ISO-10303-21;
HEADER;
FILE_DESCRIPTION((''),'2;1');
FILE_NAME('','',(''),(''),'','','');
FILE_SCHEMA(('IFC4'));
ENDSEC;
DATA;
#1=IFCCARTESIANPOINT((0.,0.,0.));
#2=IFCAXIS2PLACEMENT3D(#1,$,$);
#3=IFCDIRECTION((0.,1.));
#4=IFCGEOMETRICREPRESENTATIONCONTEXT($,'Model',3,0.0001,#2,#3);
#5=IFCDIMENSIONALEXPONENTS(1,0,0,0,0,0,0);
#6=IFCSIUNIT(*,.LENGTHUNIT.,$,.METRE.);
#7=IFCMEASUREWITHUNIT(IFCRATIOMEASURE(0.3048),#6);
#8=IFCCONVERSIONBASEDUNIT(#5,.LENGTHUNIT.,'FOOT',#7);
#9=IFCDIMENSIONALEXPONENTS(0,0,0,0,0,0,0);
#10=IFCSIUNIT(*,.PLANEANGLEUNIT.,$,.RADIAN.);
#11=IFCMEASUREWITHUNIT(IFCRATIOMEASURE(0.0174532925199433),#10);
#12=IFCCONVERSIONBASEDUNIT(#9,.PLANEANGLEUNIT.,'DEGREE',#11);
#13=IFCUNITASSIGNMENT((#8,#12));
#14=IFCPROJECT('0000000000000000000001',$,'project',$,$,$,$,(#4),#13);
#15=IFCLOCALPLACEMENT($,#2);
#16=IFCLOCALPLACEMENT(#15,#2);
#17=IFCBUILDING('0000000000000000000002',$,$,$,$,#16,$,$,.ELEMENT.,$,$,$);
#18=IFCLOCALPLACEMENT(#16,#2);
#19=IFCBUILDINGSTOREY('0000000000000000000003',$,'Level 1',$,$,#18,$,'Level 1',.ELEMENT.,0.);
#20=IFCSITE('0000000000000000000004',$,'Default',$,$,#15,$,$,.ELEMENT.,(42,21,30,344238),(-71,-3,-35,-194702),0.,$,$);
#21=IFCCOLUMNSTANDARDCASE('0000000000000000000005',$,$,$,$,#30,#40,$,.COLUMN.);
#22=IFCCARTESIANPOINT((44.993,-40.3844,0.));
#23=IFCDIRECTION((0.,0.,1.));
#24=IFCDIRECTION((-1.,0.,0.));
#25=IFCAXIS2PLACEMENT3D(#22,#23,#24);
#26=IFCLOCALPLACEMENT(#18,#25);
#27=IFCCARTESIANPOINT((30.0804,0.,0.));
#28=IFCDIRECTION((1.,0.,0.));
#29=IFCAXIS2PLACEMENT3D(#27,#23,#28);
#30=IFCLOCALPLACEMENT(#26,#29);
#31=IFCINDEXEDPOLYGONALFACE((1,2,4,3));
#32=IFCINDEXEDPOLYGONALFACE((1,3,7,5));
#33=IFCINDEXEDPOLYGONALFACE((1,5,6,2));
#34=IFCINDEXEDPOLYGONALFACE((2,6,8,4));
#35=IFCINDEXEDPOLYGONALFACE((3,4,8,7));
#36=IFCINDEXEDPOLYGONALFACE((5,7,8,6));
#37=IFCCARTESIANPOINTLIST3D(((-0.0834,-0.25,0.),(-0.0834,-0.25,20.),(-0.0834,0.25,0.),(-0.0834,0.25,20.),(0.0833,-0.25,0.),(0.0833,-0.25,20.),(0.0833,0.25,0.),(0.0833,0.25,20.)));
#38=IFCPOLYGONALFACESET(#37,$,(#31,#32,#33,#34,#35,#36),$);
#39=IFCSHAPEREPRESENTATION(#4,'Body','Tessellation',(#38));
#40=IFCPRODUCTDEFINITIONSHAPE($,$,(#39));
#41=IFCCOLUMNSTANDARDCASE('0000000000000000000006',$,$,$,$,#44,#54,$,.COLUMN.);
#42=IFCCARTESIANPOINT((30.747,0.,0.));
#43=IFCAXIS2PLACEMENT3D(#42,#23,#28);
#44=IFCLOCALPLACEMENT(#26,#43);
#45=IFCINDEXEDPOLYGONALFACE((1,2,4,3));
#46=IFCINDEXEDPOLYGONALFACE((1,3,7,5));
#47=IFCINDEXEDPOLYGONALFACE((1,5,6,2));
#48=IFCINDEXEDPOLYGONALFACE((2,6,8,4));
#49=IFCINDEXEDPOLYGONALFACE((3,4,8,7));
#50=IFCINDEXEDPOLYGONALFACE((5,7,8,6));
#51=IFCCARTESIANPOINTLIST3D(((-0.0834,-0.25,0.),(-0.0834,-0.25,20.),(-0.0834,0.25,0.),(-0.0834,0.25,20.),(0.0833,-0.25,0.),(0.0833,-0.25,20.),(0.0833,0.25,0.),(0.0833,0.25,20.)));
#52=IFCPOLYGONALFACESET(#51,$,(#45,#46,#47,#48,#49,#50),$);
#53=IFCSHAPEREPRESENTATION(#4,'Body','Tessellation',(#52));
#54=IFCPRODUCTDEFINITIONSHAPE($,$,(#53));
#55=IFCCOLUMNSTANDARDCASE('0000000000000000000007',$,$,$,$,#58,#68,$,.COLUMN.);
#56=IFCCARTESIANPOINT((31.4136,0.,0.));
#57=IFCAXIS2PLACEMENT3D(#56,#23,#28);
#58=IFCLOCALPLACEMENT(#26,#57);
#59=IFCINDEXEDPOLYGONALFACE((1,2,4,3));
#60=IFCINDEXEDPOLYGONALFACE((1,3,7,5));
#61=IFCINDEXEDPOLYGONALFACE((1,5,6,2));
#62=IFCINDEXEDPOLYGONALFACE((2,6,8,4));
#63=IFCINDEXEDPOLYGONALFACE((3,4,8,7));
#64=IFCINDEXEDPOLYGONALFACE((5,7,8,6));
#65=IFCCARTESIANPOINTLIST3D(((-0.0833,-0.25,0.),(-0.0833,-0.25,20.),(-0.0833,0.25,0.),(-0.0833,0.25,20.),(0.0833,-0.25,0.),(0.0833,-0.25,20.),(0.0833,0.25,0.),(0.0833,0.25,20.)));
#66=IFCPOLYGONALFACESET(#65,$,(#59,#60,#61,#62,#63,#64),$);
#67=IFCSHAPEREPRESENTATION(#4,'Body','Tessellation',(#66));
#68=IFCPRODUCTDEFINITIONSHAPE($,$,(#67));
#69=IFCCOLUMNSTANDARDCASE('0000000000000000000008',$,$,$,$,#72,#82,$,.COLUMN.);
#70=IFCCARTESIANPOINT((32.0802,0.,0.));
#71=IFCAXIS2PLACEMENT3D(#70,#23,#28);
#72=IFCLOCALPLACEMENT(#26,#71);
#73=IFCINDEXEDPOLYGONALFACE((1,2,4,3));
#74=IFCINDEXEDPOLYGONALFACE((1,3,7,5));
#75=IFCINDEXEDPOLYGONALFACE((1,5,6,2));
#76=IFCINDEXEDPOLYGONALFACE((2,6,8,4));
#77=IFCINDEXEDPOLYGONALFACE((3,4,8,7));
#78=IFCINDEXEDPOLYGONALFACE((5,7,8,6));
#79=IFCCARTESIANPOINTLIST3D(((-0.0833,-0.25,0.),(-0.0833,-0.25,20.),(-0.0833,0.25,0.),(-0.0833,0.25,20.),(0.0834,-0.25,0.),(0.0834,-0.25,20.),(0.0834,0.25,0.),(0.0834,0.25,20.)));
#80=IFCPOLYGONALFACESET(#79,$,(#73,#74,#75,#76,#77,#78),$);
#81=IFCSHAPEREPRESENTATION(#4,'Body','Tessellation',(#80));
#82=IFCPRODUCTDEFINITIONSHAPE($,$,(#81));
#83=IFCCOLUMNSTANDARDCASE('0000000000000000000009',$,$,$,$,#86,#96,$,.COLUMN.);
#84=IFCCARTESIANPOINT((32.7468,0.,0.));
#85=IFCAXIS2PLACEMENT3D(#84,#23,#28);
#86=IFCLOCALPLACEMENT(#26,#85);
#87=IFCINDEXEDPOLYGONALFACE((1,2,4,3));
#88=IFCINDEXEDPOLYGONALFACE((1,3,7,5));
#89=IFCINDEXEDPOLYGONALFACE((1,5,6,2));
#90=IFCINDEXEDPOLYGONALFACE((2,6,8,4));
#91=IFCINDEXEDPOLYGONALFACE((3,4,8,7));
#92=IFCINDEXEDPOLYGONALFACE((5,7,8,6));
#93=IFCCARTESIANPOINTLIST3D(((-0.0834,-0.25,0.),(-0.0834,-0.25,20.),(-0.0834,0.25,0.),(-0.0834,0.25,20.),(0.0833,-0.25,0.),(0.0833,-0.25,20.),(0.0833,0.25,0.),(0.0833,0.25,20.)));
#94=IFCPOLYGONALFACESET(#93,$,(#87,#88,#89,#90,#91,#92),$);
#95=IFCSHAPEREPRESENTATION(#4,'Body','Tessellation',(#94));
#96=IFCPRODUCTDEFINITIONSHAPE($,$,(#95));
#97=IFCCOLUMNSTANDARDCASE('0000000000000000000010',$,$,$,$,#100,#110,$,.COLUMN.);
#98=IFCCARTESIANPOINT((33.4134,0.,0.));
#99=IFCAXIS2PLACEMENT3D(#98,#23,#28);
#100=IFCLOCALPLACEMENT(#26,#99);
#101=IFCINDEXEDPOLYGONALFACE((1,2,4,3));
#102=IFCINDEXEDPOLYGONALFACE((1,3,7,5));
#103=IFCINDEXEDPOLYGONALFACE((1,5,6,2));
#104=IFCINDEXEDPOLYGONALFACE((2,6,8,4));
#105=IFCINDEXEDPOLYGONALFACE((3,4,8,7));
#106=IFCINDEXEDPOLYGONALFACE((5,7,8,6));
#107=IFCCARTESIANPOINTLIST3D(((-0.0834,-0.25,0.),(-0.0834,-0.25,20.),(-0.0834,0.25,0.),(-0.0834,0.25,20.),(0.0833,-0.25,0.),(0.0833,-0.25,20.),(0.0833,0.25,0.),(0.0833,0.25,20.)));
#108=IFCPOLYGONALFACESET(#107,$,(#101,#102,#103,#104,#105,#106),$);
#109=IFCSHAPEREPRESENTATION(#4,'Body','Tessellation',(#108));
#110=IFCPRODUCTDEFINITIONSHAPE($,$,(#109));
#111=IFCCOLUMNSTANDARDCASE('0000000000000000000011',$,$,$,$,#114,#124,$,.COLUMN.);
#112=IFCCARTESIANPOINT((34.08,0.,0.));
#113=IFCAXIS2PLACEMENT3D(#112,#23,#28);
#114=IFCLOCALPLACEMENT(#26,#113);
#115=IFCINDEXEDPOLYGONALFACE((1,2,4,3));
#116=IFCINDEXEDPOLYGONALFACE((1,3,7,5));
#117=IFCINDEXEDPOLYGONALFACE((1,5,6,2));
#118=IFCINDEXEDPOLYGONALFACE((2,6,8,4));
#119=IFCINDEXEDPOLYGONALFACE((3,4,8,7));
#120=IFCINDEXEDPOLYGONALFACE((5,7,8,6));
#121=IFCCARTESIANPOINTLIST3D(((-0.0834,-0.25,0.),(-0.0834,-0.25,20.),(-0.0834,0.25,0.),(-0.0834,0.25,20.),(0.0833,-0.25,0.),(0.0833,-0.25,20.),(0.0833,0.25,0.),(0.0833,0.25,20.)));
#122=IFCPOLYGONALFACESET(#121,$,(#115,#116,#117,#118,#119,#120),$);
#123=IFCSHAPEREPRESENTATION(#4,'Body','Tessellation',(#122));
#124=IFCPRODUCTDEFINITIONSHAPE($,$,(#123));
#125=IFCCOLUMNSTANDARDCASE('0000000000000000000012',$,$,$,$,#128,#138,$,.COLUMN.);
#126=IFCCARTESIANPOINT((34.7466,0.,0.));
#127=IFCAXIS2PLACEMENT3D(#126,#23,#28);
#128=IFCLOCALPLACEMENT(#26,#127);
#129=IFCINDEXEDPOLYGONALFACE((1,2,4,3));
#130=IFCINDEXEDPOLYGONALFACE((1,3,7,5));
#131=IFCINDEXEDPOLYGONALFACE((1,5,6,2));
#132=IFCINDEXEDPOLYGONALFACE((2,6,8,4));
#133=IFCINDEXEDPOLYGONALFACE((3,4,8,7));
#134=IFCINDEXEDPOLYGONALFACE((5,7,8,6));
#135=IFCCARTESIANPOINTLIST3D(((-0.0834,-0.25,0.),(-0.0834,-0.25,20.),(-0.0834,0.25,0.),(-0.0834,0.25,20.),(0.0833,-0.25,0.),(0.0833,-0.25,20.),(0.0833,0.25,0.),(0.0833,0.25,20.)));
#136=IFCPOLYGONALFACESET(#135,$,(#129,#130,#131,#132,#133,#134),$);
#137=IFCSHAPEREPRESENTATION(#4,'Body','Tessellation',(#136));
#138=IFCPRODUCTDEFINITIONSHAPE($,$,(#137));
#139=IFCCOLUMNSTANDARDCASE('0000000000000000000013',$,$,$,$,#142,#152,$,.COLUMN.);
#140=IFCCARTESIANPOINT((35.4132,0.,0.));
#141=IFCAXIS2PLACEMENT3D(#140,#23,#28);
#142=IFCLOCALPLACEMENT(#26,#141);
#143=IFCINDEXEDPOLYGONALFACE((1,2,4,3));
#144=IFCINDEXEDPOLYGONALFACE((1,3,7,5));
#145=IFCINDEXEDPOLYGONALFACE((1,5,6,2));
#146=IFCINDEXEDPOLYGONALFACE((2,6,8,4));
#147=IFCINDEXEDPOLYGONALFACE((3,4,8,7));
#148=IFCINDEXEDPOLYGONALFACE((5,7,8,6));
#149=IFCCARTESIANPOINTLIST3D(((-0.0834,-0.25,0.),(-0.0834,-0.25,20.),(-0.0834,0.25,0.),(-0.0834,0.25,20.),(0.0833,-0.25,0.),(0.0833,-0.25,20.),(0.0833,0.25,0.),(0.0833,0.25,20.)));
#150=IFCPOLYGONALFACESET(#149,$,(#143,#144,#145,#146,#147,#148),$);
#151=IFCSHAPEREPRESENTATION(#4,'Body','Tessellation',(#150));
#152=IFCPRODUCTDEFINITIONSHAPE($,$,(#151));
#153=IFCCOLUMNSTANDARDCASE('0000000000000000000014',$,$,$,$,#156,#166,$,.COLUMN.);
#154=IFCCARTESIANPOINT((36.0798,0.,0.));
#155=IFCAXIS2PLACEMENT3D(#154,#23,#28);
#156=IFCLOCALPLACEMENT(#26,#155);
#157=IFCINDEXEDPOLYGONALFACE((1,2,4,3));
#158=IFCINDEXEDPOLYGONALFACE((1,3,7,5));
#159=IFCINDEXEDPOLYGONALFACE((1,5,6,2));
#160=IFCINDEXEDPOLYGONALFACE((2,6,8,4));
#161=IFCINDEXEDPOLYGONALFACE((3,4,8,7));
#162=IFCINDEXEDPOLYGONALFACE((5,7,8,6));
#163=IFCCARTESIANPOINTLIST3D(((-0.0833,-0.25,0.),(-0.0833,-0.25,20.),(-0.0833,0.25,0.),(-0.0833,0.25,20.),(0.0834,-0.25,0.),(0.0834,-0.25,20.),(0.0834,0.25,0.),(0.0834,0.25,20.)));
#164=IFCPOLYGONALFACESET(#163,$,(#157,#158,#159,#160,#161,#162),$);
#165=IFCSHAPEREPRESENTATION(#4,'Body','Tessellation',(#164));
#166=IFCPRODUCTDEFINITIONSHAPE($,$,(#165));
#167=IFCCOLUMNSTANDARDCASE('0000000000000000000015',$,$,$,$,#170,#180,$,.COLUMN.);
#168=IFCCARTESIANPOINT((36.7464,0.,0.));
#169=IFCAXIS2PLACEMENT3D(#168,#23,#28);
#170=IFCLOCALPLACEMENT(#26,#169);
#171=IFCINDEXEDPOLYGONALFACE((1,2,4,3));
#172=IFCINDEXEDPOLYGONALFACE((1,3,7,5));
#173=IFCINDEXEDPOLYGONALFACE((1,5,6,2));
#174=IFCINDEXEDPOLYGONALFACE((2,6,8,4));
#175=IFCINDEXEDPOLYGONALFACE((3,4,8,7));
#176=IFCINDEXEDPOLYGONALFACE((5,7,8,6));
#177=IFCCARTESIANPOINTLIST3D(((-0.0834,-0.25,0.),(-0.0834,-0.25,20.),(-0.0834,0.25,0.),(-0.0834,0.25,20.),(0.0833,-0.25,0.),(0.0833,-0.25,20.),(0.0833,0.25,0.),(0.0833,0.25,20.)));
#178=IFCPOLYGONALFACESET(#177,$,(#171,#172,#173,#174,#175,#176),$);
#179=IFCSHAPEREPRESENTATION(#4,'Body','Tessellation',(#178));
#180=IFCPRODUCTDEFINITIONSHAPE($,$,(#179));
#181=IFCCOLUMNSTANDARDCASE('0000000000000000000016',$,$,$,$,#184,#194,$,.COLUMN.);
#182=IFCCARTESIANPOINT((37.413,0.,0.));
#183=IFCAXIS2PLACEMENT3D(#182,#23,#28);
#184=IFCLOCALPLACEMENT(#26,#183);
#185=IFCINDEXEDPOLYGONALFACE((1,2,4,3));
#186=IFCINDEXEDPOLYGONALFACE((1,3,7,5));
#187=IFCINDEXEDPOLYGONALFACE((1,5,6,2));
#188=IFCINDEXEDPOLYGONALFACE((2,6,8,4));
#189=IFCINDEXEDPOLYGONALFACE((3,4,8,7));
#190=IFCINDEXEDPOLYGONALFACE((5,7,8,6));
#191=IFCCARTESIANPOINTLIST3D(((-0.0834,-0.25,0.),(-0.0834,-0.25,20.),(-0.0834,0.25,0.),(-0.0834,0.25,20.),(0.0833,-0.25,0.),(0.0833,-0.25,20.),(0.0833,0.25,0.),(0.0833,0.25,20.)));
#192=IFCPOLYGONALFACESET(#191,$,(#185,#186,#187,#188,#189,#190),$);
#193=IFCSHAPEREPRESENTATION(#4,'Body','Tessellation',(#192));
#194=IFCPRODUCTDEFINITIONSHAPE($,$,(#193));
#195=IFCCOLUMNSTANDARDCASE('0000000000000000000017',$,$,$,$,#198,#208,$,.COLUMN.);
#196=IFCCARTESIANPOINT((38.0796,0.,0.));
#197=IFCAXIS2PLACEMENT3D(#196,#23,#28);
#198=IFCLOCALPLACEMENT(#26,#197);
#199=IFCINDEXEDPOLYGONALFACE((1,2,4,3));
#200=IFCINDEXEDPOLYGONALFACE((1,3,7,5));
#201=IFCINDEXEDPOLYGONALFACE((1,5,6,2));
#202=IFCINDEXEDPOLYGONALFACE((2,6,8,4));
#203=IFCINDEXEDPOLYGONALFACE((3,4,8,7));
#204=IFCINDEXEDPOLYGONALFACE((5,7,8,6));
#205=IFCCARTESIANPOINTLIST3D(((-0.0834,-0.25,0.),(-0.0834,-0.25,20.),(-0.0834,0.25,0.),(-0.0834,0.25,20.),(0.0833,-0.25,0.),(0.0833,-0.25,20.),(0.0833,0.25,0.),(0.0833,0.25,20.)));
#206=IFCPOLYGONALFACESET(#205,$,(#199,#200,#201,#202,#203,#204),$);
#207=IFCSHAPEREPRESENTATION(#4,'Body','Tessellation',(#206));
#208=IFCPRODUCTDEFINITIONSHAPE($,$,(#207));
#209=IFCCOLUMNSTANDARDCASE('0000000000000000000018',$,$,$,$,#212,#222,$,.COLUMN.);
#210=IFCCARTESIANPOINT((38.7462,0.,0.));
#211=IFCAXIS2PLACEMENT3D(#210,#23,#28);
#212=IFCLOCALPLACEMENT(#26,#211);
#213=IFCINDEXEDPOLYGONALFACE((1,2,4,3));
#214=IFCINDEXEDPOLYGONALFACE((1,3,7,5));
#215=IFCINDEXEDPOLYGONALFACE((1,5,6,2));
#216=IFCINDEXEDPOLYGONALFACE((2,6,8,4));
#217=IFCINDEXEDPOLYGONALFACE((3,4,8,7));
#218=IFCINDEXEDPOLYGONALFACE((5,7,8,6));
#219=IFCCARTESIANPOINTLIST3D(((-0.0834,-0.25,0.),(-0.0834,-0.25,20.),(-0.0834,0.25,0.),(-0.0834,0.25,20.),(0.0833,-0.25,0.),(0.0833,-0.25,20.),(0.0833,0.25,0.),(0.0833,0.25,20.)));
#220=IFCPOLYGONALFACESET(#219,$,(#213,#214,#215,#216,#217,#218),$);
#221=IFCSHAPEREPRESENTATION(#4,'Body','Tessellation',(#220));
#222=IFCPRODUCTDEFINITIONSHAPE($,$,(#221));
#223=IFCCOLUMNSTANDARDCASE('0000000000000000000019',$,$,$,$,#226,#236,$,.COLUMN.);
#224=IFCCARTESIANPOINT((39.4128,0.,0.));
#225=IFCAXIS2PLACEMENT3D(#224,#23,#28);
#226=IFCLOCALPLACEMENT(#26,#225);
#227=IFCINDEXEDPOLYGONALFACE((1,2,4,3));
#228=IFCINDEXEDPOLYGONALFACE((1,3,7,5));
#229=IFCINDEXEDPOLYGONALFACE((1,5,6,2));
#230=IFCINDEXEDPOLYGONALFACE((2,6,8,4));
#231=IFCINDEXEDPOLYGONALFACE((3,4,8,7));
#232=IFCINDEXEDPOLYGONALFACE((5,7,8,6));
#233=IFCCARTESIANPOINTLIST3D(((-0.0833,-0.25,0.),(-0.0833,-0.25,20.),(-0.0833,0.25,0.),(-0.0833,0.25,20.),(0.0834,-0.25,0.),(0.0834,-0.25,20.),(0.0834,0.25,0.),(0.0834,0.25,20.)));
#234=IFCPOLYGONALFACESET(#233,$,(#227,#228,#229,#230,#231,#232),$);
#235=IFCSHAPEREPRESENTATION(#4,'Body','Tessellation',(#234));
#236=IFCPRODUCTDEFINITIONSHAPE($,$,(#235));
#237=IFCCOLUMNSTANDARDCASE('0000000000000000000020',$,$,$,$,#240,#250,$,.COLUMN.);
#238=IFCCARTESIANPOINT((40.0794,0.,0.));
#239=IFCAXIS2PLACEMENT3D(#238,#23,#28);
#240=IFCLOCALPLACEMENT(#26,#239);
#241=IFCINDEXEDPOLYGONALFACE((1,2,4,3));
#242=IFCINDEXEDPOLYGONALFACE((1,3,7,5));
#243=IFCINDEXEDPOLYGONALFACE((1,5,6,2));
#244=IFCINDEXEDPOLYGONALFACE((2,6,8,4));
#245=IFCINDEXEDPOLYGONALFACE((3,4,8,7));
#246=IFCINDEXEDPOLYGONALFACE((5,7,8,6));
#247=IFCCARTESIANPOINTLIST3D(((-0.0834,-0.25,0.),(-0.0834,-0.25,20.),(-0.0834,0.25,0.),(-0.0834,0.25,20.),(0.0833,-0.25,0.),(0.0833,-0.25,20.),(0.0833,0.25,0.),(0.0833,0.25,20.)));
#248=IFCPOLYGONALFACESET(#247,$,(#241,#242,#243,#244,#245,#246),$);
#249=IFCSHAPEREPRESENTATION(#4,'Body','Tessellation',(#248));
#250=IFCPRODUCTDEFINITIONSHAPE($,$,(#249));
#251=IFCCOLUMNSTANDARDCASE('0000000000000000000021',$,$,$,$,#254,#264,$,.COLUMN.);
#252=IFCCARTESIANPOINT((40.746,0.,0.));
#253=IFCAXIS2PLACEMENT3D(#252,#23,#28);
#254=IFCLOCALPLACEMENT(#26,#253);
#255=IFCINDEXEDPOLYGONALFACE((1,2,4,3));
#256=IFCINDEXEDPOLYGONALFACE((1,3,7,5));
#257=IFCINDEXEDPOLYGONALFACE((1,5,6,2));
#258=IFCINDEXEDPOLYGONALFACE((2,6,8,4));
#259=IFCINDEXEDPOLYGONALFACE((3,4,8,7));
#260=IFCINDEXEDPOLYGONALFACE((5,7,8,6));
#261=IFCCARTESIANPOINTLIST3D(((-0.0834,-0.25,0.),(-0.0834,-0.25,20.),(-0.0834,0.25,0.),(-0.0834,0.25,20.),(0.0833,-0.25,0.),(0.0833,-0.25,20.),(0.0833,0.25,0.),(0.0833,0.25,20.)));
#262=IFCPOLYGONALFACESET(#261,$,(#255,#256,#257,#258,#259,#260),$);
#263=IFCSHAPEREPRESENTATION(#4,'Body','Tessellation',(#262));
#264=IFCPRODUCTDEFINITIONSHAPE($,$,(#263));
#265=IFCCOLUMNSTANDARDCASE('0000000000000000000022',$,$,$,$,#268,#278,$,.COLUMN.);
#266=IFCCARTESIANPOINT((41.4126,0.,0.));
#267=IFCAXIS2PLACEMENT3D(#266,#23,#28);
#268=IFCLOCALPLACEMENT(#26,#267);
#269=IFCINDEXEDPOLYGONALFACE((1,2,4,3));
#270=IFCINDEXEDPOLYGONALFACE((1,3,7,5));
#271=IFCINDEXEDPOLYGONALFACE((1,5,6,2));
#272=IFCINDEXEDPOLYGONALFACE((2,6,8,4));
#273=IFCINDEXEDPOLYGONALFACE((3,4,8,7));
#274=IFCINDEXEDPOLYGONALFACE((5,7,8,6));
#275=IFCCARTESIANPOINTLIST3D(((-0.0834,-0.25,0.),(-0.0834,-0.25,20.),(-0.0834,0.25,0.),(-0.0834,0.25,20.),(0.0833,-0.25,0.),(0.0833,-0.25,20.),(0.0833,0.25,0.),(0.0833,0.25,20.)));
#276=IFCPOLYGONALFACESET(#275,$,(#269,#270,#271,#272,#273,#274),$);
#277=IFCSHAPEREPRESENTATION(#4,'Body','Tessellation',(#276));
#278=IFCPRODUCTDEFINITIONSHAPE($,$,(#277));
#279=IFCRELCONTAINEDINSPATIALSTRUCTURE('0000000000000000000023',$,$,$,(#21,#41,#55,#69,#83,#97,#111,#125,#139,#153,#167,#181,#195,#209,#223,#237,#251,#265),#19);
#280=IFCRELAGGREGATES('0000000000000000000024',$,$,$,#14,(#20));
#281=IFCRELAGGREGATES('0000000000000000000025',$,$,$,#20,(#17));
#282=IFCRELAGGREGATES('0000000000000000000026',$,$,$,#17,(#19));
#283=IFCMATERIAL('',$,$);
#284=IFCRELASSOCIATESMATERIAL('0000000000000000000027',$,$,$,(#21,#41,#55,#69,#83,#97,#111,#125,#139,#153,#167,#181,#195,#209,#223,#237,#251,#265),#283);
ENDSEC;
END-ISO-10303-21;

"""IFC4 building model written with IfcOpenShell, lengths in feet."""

from ifc_helpers import new_model, entity, si_unit, converted_unit, direction, frame, origin, place, context, project, spatial, rectangle, extrude, material, element, save


model = new_model("IFC4")

# Units and contexts
model_context = context("Model", 3, precision=0.0001, world=origin(), true_north=direction((0.0, 1.0)))
ifc_project = project(units=[converted_unit("LENGTHUNIT", "FOOT", entity("IfcRatioMeasure", 0.3048), si_unit("LENGTHUNIT", "METRE"), dimensions=[1, 0, 0, 0, 0, 0, 0]), converted_unit("PLANEANGLEUNIT", "DEGREE", entity("IfcRatioMeasure", 0.0174532925199433), si_unit("PLANEANGLEUNIT", "RADIAN"), dimensions=[0, 0, 0, 0, 0, 0, 0])], contexts=[model_context])

# Site, building, storey
site_placement = place(None, origin())
site = spatial("IfcSite", under=ifc_project, at=site_placement, Name="Default", CompositionType="ELEMENT", RefLatitude=(42, 21, 30, 344238), RefLongitude=(-71, -3, -35, -194702), RefElevation=0.0)
building_placement = place(site_placement, origin())
building = spatial("IfcBuilding", under=site, at=building_placement, CompositionType="ELEMENT")
storey_placement = place(building_placement, origin())
storey = spatial("IfcBuildingStorey", under=building, at=storey_placement, Name="Level 1", LongName="Level 1", CompositionType="ELEMENT", Elevation=0.0)

# Columns
ifc_material_1 = material(Name="")
placement = place(storey_placement, frame((44.993, -40.3844, 0.0), z_axis=(0.0, 0.0, 1.0), x_axis=(-1.0, 0.0, 0.0)))
for number, where, z_axis, x_axis in (
    (1, (30.0804, 0.0, 0.0), (0.0, 0.0, 1.0), (1.0, 0.0, 0.0)),
    (2, (30.747, 0.0, 0.0), (0.0, 0.0, 1.0), (1.0, 0.0, 0.0)),
    (3, (31.4136, 0.0, 0.0), (0.0, 0.0, 1.0), (1.0, 0.0, 0.0)),
    (4, (32.0802, 0.0, 0.0), (0.0, 0.0, 1.0), (1.0, 0.0, 0.0)),
    (5, (32.7468, 0.0, 0.0), (0.0, 0.0, 1.0), (1.0, 0.0, 0.0)),
    (6, (33.4134, 0.0, 0.0), (0.0, 0.0, 1.0), (1.0, 0.0, 0.0)),
    (7, (34.08, 0.0, 0.0), (0.0, 0.0, 1.0), (1.0, 0.0, 0.0)),
    (8, (34.7466, 0.0, 0.0), (0.0, 0.0, 1.0), (1.0, 0.0, 0.0)),
    (9, (35.4132, 0.0, 0.0), (0.0, 0.0, 1.0), (1.0, 0.0, 0.0)),
    (10, (36.0798, 0.0, 0.0), (0.0, 0.0, 1.0), (1.0, 0.0, 0.0)),
    (11, (36.7464, 0.0, 0.0), (0.0, 0.0, 1.0), (1.0, 0.0, 0.0)),
    (12, (37.413, 0.0, 0.0), (0.0, 0.0, 1.0), (1.0, 0.0, 0.0)),
    (13, (38.0796, 0.0, 0.0), (0.0, 0.0, 1.0), (1.0, 0.0, 0.0)),
    (14, (38.7462, 0.0, 0.0), (0.0, 0.0, 1.0), (1.0, 0.0, 0.0)),
    (15, (39.4128, 0.0, 0.0), (0.0, 0.0, 1.0), (1.0, 0.0, 0.0)),
    (16, (40.0794, 0.0, 0.0), (0.0, 0.0, 1.0), (1.0, 0.0, 0.0)),
    (17, (40.746, 0.0, 0.0), (0.0, 0.0, 1.0), (1.0, 0.0, 0.0)),
    (18, (41.4126, 0.0, 0.0), (0.0, 0.0, 1.0), (1.0, 0.0, 0.0)),
):
    element("IfcColumnStandardCase", number, at=place(placement, frame(where, z_axis=z_axis, x_axis=x_axis)), inside=storey, material=ifc_material_1, PredefinedType="COLUMN", context=model_context, shape_type="SweptSolid", body=[
        extrude(rectangle(XDim=0.1667, YDim=0.5), origin(), (0.0, 0.0, 1.0), 20.0),
    ])

save(model, "model.ifc")
